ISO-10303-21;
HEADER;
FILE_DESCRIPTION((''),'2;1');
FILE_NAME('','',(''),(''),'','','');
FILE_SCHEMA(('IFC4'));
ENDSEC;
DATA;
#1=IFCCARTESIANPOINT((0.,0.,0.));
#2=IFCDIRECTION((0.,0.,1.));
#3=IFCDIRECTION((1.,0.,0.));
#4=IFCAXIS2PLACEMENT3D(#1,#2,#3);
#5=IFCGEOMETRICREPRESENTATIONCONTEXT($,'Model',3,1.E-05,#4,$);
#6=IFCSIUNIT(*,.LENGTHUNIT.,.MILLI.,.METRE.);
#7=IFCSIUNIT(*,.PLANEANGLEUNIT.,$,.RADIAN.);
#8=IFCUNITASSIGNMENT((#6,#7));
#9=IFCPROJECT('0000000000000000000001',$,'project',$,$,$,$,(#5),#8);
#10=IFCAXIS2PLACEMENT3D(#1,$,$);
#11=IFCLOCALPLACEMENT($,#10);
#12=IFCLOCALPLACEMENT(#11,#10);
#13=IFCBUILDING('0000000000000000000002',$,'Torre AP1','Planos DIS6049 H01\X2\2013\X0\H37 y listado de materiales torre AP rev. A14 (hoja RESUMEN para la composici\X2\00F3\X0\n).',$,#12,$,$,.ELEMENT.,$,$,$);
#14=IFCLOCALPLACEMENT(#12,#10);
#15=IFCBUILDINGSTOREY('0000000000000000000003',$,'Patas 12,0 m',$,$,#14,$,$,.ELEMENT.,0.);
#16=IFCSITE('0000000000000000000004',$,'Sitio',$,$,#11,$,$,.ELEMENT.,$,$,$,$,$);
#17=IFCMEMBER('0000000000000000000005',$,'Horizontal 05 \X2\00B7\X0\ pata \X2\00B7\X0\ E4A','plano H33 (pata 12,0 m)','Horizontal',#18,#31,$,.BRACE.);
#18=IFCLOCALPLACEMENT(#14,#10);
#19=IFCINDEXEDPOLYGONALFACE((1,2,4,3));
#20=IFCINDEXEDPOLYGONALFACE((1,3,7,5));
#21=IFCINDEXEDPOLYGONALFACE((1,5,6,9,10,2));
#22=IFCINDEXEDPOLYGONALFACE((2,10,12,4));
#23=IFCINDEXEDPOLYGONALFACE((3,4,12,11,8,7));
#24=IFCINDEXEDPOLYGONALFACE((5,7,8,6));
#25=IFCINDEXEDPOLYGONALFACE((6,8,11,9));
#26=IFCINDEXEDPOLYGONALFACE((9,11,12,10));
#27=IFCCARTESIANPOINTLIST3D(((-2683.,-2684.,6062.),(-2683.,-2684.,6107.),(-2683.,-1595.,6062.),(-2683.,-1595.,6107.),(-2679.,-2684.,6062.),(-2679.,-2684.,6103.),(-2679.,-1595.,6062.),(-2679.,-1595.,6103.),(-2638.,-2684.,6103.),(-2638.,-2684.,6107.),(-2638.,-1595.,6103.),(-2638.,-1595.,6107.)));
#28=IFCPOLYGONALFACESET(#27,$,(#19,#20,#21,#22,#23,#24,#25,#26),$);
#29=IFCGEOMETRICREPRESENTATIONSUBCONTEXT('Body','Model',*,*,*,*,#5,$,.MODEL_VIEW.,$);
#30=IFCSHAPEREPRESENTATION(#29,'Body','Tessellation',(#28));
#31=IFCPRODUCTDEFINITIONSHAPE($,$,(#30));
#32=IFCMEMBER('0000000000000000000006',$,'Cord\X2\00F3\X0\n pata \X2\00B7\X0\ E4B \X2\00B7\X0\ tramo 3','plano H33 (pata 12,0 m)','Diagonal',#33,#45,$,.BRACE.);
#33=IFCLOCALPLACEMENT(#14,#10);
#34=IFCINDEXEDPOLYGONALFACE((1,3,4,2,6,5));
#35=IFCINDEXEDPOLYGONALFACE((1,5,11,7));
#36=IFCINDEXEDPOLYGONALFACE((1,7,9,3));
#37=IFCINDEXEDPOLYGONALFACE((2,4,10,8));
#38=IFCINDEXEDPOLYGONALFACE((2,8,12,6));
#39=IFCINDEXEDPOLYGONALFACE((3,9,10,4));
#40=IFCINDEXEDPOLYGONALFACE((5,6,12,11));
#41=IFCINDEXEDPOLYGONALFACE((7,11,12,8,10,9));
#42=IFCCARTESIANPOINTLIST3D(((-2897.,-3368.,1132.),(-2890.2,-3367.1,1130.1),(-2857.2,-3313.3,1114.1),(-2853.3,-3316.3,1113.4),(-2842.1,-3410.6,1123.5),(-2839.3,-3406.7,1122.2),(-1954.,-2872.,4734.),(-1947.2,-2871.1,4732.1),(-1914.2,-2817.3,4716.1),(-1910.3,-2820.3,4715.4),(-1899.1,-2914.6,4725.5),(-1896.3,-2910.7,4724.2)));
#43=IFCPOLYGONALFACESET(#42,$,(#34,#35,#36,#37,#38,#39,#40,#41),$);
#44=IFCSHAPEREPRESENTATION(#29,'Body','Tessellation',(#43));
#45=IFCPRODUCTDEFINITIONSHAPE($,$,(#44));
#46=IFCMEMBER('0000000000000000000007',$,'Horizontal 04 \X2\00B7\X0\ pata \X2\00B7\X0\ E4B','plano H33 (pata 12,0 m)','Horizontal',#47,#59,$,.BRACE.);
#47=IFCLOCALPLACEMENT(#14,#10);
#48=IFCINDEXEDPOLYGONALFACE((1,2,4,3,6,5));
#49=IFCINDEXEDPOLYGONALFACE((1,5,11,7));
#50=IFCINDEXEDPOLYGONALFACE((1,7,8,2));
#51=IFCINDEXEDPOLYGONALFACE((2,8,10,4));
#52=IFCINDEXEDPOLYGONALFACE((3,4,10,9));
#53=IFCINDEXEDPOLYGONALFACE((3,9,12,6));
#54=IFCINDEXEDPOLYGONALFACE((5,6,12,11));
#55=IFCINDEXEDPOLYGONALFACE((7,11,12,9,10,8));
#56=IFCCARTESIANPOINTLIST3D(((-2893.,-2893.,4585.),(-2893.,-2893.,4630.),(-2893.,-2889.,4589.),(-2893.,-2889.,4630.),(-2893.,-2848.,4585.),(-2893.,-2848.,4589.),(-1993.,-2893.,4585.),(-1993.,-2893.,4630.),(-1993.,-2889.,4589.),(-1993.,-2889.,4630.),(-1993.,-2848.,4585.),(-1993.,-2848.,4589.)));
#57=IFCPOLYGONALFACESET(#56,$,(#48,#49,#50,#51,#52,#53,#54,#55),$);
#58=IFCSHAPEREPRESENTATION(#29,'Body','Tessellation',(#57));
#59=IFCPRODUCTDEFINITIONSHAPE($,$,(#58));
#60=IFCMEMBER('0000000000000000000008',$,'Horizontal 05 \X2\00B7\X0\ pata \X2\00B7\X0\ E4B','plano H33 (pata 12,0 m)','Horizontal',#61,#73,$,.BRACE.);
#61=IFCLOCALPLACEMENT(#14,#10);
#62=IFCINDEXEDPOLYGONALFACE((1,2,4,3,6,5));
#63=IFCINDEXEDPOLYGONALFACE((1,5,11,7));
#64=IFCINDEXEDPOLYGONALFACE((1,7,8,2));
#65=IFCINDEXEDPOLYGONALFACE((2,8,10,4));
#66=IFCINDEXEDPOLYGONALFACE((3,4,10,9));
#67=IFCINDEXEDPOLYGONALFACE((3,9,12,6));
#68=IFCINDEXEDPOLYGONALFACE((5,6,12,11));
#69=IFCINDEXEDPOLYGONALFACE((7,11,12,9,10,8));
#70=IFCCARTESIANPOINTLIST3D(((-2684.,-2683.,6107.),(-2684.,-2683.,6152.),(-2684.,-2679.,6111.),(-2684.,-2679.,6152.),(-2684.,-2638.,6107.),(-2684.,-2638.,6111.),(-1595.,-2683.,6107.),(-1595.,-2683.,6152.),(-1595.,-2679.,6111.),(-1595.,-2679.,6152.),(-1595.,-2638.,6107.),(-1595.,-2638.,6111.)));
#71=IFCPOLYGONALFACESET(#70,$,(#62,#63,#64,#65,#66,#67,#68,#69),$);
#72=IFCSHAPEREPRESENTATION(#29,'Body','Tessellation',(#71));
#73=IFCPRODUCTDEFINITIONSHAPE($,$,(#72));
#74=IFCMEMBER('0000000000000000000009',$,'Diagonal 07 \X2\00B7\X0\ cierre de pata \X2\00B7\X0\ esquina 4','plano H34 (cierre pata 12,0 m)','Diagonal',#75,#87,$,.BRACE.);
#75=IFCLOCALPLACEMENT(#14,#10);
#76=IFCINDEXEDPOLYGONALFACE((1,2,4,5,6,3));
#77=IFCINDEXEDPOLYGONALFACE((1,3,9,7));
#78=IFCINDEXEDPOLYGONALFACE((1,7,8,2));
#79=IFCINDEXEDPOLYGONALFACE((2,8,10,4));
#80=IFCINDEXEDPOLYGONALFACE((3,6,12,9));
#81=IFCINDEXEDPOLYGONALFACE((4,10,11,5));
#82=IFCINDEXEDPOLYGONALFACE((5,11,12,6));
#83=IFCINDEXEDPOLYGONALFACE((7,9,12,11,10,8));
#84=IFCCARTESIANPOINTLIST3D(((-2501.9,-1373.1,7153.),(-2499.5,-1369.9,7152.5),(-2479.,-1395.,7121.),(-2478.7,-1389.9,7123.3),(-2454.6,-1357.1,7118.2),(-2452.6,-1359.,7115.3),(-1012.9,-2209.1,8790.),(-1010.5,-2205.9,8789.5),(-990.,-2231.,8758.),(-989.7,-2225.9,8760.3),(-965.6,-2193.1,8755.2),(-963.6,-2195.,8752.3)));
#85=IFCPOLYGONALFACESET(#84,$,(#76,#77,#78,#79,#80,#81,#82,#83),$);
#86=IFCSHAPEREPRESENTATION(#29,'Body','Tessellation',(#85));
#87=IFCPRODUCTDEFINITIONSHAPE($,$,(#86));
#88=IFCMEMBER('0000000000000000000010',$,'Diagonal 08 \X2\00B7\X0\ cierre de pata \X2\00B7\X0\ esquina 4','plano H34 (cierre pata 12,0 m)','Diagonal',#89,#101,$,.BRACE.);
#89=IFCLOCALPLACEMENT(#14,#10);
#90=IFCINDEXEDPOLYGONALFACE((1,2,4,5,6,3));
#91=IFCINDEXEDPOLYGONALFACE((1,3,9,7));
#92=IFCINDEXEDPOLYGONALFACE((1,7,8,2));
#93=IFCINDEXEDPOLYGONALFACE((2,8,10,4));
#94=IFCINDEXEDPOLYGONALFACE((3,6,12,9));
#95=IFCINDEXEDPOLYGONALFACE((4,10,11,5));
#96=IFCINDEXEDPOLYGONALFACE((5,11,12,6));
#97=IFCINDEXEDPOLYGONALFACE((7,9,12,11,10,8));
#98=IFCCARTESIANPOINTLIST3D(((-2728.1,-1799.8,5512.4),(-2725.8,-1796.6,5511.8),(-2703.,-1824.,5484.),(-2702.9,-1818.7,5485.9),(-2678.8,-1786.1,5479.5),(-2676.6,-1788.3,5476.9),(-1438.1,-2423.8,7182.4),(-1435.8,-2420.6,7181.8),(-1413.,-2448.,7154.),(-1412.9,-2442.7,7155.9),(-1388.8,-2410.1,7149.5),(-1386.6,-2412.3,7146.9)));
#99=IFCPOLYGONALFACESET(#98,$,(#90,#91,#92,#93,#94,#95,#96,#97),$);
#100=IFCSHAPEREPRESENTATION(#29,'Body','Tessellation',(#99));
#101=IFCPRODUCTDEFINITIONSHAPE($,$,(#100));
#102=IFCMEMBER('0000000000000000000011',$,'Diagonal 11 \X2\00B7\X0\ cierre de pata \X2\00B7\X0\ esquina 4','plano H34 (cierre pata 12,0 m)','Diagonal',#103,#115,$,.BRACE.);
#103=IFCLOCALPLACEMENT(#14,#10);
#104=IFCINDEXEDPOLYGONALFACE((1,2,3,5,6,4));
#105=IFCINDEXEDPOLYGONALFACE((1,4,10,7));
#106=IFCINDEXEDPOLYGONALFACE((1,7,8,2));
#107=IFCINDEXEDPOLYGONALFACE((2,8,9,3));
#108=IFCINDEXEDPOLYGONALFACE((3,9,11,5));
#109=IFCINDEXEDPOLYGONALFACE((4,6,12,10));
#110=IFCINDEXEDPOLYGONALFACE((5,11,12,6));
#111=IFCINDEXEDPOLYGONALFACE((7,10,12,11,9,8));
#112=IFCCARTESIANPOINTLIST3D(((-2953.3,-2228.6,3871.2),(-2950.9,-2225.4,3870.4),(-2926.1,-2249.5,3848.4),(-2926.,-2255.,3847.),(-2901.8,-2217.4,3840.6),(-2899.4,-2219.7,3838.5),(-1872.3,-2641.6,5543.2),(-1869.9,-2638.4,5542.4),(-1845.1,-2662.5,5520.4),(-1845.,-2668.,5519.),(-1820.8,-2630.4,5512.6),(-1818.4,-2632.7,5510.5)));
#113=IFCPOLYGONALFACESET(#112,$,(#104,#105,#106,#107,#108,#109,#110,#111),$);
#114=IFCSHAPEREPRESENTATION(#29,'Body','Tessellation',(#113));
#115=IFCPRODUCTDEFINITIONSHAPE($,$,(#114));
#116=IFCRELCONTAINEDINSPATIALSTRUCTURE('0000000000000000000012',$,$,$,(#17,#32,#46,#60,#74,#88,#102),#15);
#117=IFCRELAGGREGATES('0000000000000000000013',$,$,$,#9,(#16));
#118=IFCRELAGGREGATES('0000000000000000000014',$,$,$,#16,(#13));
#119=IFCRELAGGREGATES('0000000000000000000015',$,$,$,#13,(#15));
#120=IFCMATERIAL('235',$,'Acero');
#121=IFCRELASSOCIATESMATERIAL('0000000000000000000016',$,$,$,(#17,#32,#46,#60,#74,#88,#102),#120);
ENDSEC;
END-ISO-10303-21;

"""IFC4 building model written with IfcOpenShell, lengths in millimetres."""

from ifc_helpers import new_model, si_unit, frame, frame_2d, origin, origin_with_axes, place, context, subcontext, project, spatial, l_section, extrude, material, element, save


model = new_model("IFC4")

# Units and contexts
model_context = context("Model", 3, precision=1e-05, world=origin_with_axes())
body_context = subcontext(model_context, "Body", "Model", "MODEL_VIEW")
ifc_project = project(units=[si_unit("LENGTHUNIT", "METRE", prefix="MILLI"), si_unit("PLANEANGLEUNIT", "RADIAN")], contexts=[model_context])

# Site, building, storey
site_placement = place(None, origin())
site = spatial("IfcSite", under=ifc_project, at=site_placement, Name="Sitio", CompositionType="ELEMENT")
building_placement = place(site_placement, origin())
building = spatial("IfcBuilding", under=site, at=building_placement, Name="Torre AP1", Description="Planos DIS6049 H01–H37 y listado de materiales torre AP rev. A14 (hoja RESUMEN para la composición).", CompositionType="ELEMENT")
storey_placement = place(building_placement, origin())
storey = spatial("IfcBuildingStorey", under=building, at=storey_placement, Name="Patas 12,0 m", CompositionType="ELEMENT", Elevation=0.0)

# Members
ifc_material = material(Name="235", Category="Acero")
member_1_placement = place(storey_placement, frame((-2683.0, -2684.0, 6107.0), z_axis=(0.0, 1.0, 0.0), x_axis=(1.0, 0.0, 0.0)))
element("IfcMember", 1, at=member_1_placement, inside=storey, material=ifc_material, Name="Horizontal 05 · pata · E4A", Description="plano H33 (pata 12,0 m)", ObjectType="Horizontal", PredefinedType="BRACE", context=body_context, shape_type="SweptSolid", body=[
    extrude(l_section(Depth=45.0, Width=45.0, Thickness=4.0, at=frame_2d((22.5, 22.5))), None, (0.0, 0.0, 1.0), 1089.0),
])
member_2_placement = place(storey_placement, frame((-1954.0, -2872.0, 4734.0), z_axis=(-0.251046, -0.132045, -0.958926), x_axis=(0.56819, 0.781925, -0.256424)))
element("IfcMember", 2, at=member_2_placement, inside=storey, material=ifc_material, Name="Cordón pata · E4B · tramo 3", Description="plano H33 (pata 12,0 m)", ObjectType="Diagonal", PredefinedType="BRACE", context=body_context, shape_type="SweptSolid", body=[
    extrude(l_section(Depth=70.0, Width=70.0, Thickness=5.0, at=frame_2d((35.0, 35.0))), None, (0.0, 0.0, 1.0), 3756.3),
])
member_3_placement = place(storey_placement, frame((-2893.0, -2893.0, 4585.0), z_axis=(1.0, 0.0, 0.0), x_axis=(0.0, 1.0, 0.0)))
element("IfcMember", 3, at=member_3_placement, inside=storey, material=ifc_material, Name="Horizontal 04 · pata · E4B", Description="plano H33 (pata 12,0 m)", ObjectType="Horizontal", PredefinedType="BRACE", context=body_context, shape_type="SweptSolid", body=[
    extrude(l_section(Depth=45.0, Width=45.0, Thickness=4.0, at=frame_2d((22.5, 22.5))), None, (0.0, 0.0, 1.0), 900.0),
])
member_4_placement = place(storey_placement, frame((-2684.0, -2683.0, 6107.0), z_axis=(1.0, 0.0, 0.0), x_axis=(0.0, 1.0, 0.0)))
element("IfcMember", 4, at=member_4_placement, inside=storey, material=ifc_material, Name="Horizontal 05 · pata · E4B", Description="plano H33 (pata 12,0 m)", ObjectType="Horizontal", PredefinedType="BRACE", context=body_context, shape_type="SweptSolid", body=[
    extrude(l_section(Depth=45.0, Width=45.0, Thickness=4.0, at=frame_2d((22.5, 22.5))), None, (0.0, 0.0, 1.0), 1089.0),
])
member_5_placement = place(storey_placement, frame((-2479.0, -1395.0, 7121.0), z_axis=(0.629454, -0.353407, 0.692019), x_axis=(0.587707, 0.799129, -0.126466)))
element("IfcMember", 5, at=member_5_placement, inside=storey, material=ifc_material, Name="Diagonal 07 · cierre de pata · esquina 4", Description="plano H34 (cierre pata 12,0 m)", ObjectType="Diagonal", PredefinedType="BRACE", context=body_context, shape_type="SweptSolid", body=[
    extrude(l_section(Depth=45.0, Width=45.0, Thickness=4.0, at=frame_2d((22.5, 22.5))), None, (0.0, 0.0, 1.0), 2365.5),
])
member_6_placement = place(storey_placement, frame((-2703.0, -1824.0, 5484.0), z_axis=(0.58622, -0.283567, 0.758905), x_axis=(0.587278, 0.794021, -0.156957)))
element("IfcMember", 6, at=member_6_placement, inside=storey, material=ifc_material, Name="Diagonal 08 · cierre de pata · esquina 4", Description="plano H34 (cierre pata 12,0 m)", ObjectType="Diagonal", PredefinedType="BRACE", context=body_context, shape_type="SweptSolid", body=[
    extrude(l_section(Depth=45.0, Width=45.0, Thickness=4.0, at=frame_2d((22.5, 22.5))), None, (0.0, 0.0, 1.0), 2200.5),
])
member_7_placement = place(storey_placement, frame((-2926.0, -2255.0, 3847.0), z_axis=(0.531622, -0.203108, 0.822268), x_axis=(0.591842, 0.783559, -0.189098)))
element("IfcMember", 7, at=member_7_placement, inside=storey, material=ifc_material, Name="Diagonal 11 · cierre de pata · esquina 4", Description="plano H34 (cierre pata 12,0 m)", ObjectType="Diagonal", PredefinedType="BRACE", context=body_context, shape_type="SweptSolid", body=[
    extrude(l_section(Depth=45.0, Width=45.0, Thickness=4.0, at=frame_2d((22.5, 22.5))), None, (0.0, 0.0, 1.0), 2033.4),
])

save(model, "model.ifc")
